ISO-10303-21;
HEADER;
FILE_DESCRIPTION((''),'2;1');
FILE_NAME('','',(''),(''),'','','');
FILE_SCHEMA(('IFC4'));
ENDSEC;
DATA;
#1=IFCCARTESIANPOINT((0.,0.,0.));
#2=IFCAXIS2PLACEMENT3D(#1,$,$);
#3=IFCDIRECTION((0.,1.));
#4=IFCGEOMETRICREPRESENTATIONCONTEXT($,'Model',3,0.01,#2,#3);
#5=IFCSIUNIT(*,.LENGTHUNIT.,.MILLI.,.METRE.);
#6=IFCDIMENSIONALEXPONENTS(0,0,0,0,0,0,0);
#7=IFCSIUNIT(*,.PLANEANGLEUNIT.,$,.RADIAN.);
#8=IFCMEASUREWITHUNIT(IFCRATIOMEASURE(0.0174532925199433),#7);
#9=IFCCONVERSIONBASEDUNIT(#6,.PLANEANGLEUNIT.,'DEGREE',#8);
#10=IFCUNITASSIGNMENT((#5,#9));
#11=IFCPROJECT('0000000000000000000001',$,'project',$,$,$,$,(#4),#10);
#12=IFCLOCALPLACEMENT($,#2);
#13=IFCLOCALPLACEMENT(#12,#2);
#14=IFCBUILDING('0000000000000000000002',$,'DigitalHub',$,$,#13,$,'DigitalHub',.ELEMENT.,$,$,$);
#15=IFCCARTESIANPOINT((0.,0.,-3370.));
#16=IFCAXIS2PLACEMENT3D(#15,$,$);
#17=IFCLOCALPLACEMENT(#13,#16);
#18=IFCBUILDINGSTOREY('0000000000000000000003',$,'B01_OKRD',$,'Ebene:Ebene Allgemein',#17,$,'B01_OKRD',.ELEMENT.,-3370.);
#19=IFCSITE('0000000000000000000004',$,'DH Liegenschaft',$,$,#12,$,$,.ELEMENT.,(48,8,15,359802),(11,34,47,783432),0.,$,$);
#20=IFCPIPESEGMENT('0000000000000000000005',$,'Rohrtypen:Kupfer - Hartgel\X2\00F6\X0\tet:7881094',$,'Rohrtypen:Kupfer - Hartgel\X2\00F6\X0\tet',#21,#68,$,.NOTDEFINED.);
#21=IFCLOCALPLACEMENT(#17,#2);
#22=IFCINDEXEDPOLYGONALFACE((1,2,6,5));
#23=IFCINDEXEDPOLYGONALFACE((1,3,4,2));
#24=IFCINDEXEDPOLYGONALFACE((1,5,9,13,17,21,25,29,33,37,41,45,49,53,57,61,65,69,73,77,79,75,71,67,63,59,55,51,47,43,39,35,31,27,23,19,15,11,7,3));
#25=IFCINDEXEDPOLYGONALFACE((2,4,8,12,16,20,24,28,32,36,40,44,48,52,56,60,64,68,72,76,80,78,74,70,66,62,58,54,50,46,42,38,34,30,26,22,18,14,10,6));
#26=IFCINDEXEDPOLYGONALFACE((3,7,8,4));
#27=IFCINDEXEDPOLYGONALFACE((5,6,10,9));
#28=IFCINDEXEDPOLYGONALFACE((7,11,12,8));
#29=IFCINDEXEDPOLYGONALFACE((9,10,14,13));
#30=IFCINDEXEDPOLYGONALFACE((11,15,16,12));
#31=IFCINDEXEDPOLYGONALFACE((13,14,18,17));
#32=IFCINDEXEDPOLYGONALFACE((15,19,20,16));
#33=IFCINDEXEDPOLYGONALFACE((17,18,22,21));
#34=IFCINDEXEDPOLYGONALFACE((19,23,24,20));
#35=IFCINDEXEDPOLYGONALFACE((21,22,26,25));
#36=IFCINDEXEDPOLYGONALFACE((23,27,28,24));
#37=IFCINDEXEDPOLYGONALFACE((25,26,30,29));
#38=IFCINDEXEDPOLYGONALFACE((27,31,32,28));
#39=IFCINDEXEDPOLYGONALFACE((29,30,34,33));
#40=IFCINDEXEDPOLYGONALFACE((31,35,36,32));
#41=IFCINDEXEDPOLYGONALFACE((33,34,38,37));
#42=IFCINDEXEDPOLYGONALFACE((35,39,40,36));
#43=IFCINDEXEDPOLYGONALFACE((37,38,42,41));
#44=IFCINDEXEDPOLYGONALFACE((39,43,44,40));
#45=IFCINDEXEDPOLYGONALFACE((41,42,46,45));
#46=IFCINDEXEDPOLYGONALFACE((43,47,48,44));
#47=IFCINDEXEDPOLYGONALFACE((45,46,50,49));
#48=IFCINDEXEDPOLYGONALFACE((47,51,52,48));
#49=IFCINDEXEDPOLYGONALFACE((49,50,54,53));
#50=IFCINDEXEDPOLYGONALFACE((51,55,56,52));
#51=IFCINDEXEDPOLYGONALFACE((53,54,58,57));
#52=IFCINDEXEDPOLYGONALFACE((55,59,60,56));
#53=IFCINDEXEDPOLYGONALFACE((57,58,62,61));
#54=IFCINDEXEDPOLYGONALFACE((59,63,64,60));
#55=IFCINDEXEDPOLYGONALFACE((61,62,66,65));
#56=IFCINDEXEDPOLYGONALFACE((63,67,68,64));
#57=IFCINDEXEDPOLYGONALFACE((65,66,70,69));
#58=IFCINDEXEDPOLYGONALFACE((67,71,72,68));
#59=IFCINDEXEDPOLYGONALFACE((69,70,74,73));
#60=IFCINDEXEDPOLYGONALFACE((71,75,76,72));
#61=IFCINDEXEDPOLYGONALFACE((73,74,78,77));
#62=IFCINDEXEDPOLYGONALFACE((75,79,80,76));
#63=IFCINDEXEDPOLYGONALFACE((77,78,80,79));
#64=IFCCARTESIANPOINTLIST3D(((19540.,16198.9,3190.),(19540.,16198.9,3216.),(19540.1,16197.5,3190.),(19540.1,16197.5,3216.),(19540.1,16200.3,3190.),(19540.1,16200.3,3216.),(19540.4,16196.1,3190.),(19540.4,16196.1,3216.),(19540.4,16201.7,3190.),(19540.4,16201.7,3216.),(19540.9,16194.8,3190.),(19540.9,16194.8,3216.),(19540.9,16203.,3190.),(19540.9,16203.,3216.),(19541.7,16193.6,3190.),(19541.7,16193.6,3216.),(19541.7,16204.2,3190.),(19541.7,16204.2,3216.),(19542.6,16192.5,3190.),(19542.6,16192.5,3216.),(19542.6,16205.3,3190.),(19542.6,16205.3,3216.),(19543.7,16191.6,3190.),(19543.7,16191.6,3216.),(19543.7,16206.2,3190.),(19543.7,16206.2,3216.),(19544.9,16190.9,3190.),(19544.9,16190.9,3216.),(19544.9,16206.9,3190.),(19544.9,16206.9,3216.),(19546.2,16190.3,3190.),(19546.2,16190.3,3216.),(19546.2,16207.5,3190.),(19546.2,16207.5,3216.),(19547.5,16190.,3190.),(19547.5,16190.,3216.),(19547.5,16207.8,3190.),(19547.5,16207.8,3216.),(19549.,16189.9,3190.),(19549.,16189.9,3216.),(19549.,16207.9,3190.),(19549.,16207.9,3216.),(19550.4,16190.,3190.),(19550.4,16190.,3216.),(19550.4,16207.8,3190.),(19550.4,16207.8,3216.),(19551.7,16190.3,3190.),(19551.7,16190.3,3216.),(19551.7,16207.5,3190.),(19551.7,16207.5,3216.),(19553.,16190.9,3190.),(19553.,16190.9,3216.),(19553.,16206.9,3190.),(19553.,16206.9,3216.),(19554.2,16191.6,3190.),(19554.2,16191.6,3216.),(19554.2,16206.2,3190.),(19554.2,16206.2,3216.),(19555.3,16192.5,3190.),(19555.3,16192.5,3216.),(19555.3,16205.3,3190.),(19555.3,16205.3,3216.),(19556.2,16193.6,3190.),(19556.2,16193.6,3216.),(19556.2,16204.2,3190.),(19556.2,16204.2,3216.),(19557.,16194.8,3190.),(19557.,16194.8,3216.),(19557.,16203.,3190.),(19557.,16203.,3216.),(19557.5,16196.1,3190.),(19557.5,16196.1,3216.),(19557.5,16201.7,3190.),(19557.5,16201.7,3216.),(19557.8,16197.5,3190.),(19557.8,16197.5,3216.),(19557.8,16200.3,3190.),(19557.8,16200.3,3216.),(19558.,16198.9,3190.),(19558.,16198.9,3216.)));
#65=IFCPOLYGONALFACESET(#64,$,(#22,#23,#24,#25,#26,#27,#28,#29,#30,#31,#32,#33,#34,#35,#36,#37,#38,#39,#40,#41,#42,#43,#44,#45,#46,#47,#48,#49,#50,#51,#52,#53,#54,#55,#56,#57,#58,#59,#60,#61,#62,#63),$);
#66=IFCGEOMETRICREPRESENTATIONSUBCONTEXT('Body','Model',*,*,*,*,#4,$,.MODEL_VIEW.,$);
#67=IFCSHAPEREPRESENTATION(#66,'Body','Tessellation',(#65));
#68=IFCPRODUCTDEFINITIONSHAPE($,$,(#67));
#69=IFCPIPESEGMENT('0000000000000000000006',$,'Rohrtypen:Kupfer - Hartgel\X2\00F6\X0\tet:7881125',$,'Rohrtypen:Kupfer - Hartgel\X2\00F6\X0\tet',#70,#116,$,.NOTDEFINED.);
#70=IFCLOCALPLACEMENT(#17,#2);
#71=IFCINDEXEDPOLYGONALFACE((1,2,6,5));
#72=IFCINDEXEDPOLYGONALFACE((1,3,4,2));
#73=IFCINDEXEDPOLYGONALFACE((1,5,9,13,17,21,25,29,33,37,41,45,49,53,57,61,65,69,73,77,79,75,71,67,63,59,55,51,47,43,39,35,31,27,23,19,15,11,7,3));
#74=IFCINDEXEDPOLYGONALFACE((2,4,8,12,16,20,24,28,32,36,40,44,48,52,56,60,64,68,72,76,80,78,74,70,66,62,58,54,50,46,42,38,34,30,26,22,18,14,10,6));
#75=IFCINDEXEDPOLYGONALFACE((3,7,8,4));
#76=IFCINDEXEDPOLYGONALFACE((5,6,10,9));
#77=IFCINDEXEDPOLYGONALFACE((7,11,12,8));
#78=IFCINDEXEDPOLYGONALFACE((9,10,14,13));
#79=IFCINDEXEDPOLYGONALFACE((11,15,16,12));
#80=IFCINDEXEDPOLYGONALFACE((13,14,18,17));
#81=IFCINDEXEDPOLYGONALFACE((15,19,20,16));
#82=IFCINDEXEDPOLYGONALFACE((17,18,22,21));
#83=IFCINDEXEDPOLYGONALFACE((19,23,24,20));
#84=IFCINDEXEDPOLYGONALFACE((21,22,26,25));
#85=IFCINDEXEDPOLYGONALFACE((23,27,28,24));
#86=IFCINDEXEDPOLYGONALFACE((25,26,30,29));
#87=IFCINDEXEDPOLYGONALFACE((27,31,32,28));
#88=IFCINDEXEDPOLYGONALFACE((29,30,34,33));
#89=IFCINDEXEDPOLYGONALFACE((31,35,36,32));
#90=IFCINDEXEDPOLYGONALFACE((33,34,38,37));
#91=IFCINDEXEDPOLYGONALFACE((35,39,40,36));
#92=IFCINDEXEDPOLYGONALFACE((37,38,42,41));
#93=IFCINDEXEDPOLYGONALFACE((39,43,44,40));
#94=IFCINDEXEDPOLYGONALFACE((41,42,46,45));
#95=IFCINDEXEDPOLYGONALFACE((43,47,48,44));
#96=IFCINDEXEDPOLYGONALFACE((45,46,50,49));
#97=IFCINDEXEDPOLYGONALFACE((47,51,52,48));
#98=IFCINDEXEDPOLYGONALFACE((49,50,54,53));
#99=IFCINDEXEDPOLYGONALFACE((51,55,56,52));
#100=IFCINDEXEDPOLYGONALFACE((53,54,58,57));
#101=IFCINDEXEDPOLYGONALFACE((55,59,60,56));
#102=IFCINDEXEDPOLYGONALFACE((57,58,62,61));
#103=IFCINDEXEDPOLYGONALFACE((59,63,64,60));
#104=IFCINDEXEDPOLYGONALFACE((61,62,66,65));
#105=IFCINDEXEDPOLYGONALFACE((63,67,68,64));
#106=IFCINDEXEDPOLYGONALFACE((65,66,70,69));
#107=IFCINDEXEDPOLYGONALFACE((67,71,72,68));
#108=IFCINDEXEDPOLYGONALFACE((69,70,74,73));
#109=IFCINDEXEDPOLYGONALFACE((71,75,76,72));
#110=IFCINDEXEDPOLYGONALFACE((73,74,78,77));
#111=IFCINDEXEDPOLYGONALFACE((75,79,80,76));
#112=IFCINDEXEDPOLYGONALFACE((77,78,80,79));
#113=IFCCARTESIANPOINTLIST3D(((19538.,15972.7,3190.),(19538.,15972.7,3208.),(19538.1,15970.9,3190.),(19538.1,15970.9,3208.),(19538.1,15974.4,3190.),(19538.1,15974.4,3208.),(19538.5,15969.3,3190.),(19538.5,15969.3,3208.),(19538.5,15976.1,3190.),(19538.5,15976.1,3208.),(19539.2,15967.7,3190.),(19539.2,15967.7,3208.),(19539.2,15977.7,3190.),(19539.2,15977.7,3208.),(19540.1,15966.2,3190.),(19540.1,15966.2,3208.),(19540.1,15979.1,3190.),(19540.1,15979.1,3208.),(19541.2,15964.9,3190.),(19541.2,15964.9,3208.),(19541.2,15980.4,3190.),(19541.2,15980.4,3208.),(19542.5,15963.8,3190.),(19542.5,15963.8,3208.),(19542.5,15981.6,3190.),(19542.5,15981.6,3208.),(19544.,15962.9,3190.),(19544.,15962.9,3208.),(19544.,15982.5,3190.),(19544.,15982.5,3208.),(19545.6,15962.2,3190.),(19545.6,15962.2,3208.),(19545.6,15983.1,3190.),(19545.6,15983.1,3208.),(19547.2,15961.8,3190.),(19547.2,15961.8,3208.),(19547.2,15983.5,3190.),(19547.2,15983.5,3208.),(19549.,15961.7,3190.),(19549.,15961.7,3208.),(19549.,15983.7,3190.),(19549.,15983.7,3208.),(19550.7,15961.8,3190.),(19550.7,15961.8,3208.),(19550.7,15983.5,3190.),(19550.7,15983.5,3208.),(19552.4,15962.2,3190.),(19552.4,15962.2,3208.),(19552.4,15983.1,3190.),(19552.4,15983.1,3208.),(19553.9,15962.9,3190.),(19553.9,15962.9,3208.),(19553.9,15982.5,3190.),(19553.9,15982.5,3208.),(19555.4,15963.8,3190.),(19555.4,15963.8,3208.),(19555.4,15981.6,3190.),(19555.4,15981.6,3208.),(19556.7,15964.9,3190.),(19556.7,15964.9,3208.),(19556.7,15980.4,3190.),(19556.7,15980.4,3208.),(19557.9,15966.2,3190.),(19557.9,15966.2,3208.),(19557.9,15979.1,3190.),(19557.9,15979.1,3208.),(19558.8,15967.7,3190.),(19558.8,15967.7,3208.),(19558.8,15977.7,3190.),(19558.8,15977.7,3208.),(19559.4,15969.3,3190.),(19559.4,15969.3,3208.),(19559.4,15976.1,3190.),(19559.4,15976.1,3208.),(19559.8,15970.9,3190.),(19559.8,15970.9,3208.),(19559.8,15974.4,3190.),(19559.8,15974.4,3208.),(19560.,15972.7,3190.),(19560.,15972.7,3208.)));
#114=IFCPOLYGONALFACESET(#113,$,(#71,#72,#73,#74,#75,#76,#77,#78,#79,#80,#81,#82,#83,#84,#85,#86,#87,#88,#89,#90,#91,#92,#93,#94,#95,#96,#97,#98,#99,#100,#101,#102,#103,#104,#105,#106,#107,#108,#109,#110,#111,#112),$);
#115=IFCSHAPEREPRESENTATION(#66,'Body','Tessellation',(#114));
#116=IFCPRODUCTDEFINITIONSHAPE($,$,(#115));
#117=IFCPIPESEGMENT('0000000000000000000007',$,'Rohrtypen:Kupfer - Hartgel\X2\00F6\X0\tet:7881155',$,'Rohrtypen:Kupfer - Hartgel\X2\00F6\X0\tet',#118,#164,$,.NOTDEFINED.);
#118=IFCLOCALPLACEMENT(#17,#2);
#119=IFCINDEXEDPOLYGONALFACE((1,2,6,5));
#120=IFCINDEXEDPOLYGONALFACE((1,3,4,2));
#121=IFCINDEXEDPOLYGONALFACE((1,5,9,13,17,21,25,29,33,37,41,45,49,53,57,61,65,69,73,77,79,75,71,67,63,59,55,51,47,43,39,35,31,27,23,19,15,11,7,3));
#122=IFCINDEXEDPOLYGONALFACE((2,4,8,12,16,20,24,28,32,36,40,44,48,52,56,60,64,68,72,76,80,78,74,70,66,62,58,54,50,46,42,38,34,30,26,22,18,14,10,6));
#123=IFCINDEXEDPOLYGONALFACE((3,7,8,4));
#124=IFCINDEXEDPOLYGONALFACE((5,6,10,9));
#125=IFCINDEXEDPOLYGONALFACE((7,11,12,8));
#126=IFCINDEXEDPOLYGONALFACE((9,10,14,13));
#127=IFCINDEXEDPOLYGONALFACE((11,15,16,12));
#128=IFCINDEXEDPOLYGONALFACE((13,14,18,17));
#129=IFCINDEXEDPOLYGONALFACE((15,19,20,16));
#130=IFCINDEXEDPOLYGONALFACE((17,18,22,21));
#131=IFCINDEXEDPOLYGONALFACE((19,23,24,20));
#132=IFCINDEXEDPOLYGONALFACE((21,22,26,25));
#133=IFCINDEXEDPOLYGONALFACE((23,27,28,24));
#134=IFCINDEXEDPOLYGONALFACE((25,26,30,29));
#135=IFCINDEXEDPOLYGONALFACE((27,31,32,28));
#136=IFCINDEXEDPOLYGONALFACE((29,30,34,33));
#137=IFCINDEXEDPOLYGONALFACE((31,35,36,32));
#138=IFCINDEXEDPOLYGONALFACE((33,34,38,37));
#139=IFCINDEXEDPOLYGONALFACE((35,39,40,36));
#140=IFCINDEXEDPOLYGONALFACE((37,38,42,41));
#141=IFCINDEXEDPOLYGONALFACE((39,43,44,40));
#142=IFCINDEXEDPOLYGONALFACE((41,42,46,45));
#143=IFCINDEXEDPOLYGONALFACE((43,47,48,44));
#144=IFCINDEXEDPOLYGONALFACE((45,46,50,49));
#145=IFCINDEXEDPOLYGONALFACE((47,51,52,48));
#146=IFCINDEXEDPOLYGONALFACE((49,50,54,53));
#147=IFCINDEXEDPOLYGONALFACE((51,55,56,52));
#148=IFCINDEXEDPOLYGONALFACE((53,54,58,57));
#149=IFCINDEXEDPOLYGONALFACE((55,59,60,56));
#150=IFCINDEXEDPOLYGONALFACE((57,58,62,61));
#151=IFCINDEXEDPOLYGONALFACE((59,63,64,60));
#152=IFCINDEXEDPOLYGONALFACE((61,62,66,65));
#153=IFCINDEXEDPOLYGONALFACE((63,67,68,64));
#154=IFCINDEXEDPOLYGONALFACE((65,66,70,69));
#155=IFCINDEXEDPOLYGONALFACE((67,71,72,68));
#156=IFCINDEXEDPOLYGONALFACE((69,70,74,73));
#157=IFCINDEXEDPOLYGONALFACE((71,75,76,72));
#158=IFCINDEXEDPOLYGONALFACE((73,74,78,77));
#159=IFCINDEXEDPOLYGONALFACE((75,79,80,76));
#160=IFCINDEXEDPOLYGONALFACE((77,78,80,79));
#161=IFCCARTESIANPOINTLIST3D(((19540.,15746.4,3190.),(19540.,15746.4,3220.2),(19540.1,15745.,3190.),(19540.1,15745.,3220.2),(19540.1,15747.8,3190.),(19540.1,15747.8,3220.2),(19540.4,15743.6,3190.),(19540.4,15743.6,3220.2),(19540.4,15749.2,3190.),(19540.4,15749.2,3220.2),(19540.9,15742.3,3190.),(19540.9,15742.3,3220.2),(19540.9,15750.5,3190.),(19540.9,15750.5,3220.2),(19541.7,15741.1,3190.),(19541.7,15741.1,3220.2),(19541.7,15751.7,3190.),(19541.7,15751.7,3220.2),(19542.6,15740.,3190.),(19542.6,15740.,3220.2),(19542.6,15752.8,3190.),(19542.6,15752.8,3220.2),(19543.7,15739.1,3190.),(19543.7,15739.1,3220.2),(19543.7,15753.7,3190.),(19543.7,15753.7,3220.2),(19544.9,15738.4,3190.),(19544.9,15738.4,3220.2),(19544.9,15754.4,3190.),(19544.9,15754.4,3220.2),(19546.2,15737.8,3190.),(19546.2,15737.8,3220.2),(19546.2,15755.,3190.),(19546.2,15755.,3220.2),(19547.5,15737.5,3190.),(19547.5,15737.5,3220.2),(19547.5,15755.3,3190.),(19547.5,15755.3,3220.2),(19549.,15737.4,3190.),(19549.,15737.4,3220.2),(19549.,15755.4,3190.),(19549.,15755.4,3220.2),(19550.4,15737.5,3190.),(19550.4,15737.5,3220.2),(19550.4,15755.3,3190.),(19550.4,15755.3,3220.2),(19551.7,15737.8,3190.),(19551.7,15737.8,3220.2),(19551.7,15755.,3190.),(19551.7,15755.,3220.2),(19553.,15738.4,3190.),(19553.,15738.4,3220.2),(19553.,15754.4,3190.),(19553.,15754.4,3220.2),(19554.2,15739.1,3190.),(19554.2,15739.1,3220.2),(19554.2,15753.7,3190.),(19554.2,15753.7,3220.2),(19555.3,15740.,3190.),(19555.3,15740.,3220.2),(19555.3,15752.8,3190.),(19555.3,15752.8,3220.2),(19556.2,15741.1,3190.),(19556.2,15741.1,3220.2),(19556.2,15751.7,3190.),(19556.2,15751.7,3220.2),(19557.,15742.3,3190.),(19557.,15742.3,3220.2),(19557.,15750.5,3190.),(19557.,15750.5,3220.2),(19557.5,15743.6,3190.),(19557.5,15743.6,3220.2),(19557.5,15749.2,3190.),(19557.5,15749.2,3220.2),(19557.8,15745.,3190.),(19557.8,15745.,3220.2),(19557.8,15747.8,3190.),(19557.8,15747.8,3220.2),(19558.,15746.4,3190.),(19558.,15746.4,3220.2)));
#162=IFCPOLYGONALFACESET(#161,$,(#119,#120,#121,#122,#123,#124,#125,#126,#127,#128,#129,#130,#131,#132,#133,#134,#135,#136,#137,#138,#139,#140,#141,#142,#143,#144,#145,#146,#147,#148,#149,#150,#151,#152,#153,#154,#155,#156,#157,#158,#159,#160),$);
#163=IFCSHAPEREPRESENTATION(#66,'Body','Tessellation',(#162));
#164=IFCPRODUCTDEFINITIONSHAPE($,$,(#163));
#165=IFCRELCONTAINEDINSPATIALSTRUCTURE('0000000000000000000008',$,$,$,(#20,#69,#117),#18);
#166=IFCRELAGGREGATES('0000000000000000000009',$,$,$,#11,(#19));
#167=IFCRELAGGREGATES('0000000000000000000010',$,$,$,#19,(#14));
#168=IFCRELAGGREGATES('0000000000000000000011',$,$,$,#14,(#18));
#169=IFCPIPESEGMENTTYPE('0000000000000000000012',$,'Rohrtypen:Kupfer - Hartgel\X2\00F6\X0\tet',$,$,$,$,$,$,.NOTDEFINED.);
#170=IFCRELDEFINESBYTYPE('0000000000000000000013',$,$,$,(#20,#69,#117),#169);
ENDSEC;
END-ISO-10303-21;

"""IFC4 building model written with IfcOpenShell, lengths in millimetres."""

from ifc_helpers import new_model, entity, si_unit, converted_unit, direction, frame, origin, place, context, subcontext, project, spatial, indexed_curve, outline, extrude, type_object, element, save


model = new_model("IFC4")

# Units and contexts
model_context = context("Model", 3, precision=0.01, world=origin(), true_north=direction((0.0, 1.0)))
body_context = subcontext(model_context, "Body", "Model", "MODEL_VIEW")
ifc_project = project(units=[si_unit("LENGTHUNIT", "METRE", prefix="MILLI"), converted_unit("PLANEANGLEUNIT", "DEGREE", entity("IfcRatioMeasure", 0.0174532925199433), si_unit("PLANEANGLEUNIT", "RADIAN"), dimensions=[0, 0, 0, 0, 0, 0, 0])], contexts=[model_context])

# Site, building, storey
site_placement = place(None, origin())
site = spatial("IfcSite", under=ifc_project, at=site_placement, Name="DH Liegenschaft", CompositionType="ELEMENT", RefLatitude=(48, 8, 15, 359802), RefLongitude=(11, 34, 47, 783432), RefElevation=0.0)
building_placement = place(site_placement, origin())
building = spatial("IfcBuilding", under=site, at=building_placement, Name="DigitalHub", LongName="DigitalHub", CompositionType="ELEMENT")
storey_placement = place(building_placement, frame((0.0, 0.0, -3370.0)))
storey = spatial("IfcBuildingStorey", under=building, at=storey_placement, Name="B01_OKRD", ObjectType="Ebene:Ebene Allgemein", LongName="B01_OKRD", CompositionType="ELEMENT", Elevation=-3370.0)

# Pipe segments
pipe_segment_type = type_object("IfcPipeSegmentType", Name="Rohrtypen:Kupfer - Hartgelötet", PredefinedType="NOTDEFINED")
pipe_segment_1_placement = place(storey_placement, frame((19538.4, 16188.3, 3190.0)))
element("IfcPipeSegment", 1, at=pipe_segment_1_placement, inside=storey, type_object=pipe_segment_type, Name="Rohrtypen:Kupfer - Hartgelötet:7881094", ObjectType="Rohrtypen:Kupfer - Hartgelötet", PredefinedType="NOTDEFINED", context=body_context, shape_type="SweptSolid", body=[
    extrude(outline(indexed_curve([(9.0, 0.0), (8.9, 1.4), (8.6, 2.8), (8.0, 4.1), (7.3, 5.3), (6.4, 6.4), (5.3, 7.3), (4.1, 8.0), (2.8, 8.6), (1.4, 8.9), (0.0, 9.0), (-1.4, 8.9), (-2.8, 8.6), (-4.1, 8.0), (-5.3, 7.3), (-6.4, 6.4), (-7.3, 5.3), (-8.0, 4.1), (-8.6, 2.8), (-8.9, 1.4), (-9.0, 0.0), (-8.9, -1.4), (-8.6, -2.8), (-8.0, -4.1), (-7.3, -5.3), (-6.4, -6.4), (-5.3, -7.3), (-4.1, -8.0), (-2.8, -8.6), (-1.4, -8.9), (0.0, -9.0), (1.4, -8.9), (2.8, -8.6), (4.1, -8.0), (5.3, -7.3), (6.4, -6.4), (7.3, -5.3), (8.0, -4.1), (8.6, -2.8), (8.9, -1.4), (9.0, 0.0)], self_intersect=False)), frame((10.6, 10.6, 0.0)), (0.0, 0.0, 1.0), 26.0),
])
pipe_segment_2_placement = place(storey_placement, frame((19536.4, 15960.1, 3190.0)))
element("IfcPipeSegment", 2, at=pipe_segment_2_placement, inside=storey, type_object=pipe_segment_type, Name="Rohrtypen:Kupfer - Hartgelötet:7881125", ObjectType="Rohrtypen:Kupfer - Hartgelötet", PredefinedType="NOTDEFINED", context=body_context, shape_type="SweptSolid", body=[
    extrude(outline(indexed_curve([(11.0, 0.0), (10.9, 1.7), (10.5, 3.4), (9.8, 5.0), (8.9, 6.5), (7.8, 7.8), (6.5, 8.9), (5.0, 9.8), (3.4, 10.5), (1.7, 10.9), (0.0, 11.0), (-1.7, 10.9), (-3.4, 10.5), (-5.0, 9.8), (-6.5, 8.9), (-7.8, 7.8), (-8.9, 6.5), (-9.8, 5.0), (-10.5, 3.4), (-10.9, 1.7), (-11.0, 0.0), (-10.9, -1.7), (-10.5, -3.4), (-9.8, -5.0), (-8.9, -6.5), (-7.8, -7.8), (-6.5, -8.9), (-5.0, -9.8), (-3.4, -10.5), (-1.7, -10.9), (0.0, -11.0), (1.7, -10.9), (3.4, -10.5), (5.0, -9.8), (6.5, -8.9), (7.8, -7.8), (8.9, -6.5), (9.8, -5.0), (10.5, -3.4), (10.9, -1.7), (11.0, 0.0)], self_intersect=False)), frame((12.6, 12.6, 0.0)), (0.0, 0.0, 1.0), 18.0),
])
pipe_segment_3_placement = place(storey_placement, frame((19538.4, 15735.8, 3190.0)))
element("IfcPipeSegment", 3, at=pipe_segment_3_placement, inside=storey, type_object=pipe_segment_type, Name="Rohrtypen:Kupfer - Hartgelötet:7881155", ObjectType="Rohrtypen:Kupfer - Hartgelötet", PredefinedType="NOTDEFINED", context=body_context, shape_type="SweptSolid", body=[
    extrude(outline(indexed_curve([(9.0, 0.0), (8.9, 1.4), (8.6, 2.8), (8.0, 4.1), (7.3, 5.3), (6.4, 6.4), (5.3, 7.3), (4.1, 8.0), (2.8, 8.6), (1.4, 8.9), (0.0, 9.0), (-1.4, 8.9), (-2.8, 8.6), (-4.1, 8.0), (-5.3, 7.3), (-6.4, 6.4), (-7.3, 5.3), (-8.0, 4.1), (-8.6, 2.8), (-8.9, 1.4), (-9.0, 0.0), (-8.9, -1.4), (-8.6, -2.8), (-8.0, -4.1), (-7.3, -5.3), (-6.4, -6.4), (-5.3, -7.3), (-4.1, -8.0), (-2.8, -8.6), (-1.4, -8.9), (0.0, -9.0), (1.4, -8.9), (2.8, -8.6), (4.1, -8.0), (5.3, -7.3), (6.4, -6.4), (7.3, -5.3), (8.0, -4.1), (8.6, -2.8), (8.9, -1.4), (9.0, 0.0)], self_intersect=False)), frame((10.6, 10.6, 0.0)), (0.0, 0.0, 1.0), 30.2),
])

save(model, "model.ifc")
